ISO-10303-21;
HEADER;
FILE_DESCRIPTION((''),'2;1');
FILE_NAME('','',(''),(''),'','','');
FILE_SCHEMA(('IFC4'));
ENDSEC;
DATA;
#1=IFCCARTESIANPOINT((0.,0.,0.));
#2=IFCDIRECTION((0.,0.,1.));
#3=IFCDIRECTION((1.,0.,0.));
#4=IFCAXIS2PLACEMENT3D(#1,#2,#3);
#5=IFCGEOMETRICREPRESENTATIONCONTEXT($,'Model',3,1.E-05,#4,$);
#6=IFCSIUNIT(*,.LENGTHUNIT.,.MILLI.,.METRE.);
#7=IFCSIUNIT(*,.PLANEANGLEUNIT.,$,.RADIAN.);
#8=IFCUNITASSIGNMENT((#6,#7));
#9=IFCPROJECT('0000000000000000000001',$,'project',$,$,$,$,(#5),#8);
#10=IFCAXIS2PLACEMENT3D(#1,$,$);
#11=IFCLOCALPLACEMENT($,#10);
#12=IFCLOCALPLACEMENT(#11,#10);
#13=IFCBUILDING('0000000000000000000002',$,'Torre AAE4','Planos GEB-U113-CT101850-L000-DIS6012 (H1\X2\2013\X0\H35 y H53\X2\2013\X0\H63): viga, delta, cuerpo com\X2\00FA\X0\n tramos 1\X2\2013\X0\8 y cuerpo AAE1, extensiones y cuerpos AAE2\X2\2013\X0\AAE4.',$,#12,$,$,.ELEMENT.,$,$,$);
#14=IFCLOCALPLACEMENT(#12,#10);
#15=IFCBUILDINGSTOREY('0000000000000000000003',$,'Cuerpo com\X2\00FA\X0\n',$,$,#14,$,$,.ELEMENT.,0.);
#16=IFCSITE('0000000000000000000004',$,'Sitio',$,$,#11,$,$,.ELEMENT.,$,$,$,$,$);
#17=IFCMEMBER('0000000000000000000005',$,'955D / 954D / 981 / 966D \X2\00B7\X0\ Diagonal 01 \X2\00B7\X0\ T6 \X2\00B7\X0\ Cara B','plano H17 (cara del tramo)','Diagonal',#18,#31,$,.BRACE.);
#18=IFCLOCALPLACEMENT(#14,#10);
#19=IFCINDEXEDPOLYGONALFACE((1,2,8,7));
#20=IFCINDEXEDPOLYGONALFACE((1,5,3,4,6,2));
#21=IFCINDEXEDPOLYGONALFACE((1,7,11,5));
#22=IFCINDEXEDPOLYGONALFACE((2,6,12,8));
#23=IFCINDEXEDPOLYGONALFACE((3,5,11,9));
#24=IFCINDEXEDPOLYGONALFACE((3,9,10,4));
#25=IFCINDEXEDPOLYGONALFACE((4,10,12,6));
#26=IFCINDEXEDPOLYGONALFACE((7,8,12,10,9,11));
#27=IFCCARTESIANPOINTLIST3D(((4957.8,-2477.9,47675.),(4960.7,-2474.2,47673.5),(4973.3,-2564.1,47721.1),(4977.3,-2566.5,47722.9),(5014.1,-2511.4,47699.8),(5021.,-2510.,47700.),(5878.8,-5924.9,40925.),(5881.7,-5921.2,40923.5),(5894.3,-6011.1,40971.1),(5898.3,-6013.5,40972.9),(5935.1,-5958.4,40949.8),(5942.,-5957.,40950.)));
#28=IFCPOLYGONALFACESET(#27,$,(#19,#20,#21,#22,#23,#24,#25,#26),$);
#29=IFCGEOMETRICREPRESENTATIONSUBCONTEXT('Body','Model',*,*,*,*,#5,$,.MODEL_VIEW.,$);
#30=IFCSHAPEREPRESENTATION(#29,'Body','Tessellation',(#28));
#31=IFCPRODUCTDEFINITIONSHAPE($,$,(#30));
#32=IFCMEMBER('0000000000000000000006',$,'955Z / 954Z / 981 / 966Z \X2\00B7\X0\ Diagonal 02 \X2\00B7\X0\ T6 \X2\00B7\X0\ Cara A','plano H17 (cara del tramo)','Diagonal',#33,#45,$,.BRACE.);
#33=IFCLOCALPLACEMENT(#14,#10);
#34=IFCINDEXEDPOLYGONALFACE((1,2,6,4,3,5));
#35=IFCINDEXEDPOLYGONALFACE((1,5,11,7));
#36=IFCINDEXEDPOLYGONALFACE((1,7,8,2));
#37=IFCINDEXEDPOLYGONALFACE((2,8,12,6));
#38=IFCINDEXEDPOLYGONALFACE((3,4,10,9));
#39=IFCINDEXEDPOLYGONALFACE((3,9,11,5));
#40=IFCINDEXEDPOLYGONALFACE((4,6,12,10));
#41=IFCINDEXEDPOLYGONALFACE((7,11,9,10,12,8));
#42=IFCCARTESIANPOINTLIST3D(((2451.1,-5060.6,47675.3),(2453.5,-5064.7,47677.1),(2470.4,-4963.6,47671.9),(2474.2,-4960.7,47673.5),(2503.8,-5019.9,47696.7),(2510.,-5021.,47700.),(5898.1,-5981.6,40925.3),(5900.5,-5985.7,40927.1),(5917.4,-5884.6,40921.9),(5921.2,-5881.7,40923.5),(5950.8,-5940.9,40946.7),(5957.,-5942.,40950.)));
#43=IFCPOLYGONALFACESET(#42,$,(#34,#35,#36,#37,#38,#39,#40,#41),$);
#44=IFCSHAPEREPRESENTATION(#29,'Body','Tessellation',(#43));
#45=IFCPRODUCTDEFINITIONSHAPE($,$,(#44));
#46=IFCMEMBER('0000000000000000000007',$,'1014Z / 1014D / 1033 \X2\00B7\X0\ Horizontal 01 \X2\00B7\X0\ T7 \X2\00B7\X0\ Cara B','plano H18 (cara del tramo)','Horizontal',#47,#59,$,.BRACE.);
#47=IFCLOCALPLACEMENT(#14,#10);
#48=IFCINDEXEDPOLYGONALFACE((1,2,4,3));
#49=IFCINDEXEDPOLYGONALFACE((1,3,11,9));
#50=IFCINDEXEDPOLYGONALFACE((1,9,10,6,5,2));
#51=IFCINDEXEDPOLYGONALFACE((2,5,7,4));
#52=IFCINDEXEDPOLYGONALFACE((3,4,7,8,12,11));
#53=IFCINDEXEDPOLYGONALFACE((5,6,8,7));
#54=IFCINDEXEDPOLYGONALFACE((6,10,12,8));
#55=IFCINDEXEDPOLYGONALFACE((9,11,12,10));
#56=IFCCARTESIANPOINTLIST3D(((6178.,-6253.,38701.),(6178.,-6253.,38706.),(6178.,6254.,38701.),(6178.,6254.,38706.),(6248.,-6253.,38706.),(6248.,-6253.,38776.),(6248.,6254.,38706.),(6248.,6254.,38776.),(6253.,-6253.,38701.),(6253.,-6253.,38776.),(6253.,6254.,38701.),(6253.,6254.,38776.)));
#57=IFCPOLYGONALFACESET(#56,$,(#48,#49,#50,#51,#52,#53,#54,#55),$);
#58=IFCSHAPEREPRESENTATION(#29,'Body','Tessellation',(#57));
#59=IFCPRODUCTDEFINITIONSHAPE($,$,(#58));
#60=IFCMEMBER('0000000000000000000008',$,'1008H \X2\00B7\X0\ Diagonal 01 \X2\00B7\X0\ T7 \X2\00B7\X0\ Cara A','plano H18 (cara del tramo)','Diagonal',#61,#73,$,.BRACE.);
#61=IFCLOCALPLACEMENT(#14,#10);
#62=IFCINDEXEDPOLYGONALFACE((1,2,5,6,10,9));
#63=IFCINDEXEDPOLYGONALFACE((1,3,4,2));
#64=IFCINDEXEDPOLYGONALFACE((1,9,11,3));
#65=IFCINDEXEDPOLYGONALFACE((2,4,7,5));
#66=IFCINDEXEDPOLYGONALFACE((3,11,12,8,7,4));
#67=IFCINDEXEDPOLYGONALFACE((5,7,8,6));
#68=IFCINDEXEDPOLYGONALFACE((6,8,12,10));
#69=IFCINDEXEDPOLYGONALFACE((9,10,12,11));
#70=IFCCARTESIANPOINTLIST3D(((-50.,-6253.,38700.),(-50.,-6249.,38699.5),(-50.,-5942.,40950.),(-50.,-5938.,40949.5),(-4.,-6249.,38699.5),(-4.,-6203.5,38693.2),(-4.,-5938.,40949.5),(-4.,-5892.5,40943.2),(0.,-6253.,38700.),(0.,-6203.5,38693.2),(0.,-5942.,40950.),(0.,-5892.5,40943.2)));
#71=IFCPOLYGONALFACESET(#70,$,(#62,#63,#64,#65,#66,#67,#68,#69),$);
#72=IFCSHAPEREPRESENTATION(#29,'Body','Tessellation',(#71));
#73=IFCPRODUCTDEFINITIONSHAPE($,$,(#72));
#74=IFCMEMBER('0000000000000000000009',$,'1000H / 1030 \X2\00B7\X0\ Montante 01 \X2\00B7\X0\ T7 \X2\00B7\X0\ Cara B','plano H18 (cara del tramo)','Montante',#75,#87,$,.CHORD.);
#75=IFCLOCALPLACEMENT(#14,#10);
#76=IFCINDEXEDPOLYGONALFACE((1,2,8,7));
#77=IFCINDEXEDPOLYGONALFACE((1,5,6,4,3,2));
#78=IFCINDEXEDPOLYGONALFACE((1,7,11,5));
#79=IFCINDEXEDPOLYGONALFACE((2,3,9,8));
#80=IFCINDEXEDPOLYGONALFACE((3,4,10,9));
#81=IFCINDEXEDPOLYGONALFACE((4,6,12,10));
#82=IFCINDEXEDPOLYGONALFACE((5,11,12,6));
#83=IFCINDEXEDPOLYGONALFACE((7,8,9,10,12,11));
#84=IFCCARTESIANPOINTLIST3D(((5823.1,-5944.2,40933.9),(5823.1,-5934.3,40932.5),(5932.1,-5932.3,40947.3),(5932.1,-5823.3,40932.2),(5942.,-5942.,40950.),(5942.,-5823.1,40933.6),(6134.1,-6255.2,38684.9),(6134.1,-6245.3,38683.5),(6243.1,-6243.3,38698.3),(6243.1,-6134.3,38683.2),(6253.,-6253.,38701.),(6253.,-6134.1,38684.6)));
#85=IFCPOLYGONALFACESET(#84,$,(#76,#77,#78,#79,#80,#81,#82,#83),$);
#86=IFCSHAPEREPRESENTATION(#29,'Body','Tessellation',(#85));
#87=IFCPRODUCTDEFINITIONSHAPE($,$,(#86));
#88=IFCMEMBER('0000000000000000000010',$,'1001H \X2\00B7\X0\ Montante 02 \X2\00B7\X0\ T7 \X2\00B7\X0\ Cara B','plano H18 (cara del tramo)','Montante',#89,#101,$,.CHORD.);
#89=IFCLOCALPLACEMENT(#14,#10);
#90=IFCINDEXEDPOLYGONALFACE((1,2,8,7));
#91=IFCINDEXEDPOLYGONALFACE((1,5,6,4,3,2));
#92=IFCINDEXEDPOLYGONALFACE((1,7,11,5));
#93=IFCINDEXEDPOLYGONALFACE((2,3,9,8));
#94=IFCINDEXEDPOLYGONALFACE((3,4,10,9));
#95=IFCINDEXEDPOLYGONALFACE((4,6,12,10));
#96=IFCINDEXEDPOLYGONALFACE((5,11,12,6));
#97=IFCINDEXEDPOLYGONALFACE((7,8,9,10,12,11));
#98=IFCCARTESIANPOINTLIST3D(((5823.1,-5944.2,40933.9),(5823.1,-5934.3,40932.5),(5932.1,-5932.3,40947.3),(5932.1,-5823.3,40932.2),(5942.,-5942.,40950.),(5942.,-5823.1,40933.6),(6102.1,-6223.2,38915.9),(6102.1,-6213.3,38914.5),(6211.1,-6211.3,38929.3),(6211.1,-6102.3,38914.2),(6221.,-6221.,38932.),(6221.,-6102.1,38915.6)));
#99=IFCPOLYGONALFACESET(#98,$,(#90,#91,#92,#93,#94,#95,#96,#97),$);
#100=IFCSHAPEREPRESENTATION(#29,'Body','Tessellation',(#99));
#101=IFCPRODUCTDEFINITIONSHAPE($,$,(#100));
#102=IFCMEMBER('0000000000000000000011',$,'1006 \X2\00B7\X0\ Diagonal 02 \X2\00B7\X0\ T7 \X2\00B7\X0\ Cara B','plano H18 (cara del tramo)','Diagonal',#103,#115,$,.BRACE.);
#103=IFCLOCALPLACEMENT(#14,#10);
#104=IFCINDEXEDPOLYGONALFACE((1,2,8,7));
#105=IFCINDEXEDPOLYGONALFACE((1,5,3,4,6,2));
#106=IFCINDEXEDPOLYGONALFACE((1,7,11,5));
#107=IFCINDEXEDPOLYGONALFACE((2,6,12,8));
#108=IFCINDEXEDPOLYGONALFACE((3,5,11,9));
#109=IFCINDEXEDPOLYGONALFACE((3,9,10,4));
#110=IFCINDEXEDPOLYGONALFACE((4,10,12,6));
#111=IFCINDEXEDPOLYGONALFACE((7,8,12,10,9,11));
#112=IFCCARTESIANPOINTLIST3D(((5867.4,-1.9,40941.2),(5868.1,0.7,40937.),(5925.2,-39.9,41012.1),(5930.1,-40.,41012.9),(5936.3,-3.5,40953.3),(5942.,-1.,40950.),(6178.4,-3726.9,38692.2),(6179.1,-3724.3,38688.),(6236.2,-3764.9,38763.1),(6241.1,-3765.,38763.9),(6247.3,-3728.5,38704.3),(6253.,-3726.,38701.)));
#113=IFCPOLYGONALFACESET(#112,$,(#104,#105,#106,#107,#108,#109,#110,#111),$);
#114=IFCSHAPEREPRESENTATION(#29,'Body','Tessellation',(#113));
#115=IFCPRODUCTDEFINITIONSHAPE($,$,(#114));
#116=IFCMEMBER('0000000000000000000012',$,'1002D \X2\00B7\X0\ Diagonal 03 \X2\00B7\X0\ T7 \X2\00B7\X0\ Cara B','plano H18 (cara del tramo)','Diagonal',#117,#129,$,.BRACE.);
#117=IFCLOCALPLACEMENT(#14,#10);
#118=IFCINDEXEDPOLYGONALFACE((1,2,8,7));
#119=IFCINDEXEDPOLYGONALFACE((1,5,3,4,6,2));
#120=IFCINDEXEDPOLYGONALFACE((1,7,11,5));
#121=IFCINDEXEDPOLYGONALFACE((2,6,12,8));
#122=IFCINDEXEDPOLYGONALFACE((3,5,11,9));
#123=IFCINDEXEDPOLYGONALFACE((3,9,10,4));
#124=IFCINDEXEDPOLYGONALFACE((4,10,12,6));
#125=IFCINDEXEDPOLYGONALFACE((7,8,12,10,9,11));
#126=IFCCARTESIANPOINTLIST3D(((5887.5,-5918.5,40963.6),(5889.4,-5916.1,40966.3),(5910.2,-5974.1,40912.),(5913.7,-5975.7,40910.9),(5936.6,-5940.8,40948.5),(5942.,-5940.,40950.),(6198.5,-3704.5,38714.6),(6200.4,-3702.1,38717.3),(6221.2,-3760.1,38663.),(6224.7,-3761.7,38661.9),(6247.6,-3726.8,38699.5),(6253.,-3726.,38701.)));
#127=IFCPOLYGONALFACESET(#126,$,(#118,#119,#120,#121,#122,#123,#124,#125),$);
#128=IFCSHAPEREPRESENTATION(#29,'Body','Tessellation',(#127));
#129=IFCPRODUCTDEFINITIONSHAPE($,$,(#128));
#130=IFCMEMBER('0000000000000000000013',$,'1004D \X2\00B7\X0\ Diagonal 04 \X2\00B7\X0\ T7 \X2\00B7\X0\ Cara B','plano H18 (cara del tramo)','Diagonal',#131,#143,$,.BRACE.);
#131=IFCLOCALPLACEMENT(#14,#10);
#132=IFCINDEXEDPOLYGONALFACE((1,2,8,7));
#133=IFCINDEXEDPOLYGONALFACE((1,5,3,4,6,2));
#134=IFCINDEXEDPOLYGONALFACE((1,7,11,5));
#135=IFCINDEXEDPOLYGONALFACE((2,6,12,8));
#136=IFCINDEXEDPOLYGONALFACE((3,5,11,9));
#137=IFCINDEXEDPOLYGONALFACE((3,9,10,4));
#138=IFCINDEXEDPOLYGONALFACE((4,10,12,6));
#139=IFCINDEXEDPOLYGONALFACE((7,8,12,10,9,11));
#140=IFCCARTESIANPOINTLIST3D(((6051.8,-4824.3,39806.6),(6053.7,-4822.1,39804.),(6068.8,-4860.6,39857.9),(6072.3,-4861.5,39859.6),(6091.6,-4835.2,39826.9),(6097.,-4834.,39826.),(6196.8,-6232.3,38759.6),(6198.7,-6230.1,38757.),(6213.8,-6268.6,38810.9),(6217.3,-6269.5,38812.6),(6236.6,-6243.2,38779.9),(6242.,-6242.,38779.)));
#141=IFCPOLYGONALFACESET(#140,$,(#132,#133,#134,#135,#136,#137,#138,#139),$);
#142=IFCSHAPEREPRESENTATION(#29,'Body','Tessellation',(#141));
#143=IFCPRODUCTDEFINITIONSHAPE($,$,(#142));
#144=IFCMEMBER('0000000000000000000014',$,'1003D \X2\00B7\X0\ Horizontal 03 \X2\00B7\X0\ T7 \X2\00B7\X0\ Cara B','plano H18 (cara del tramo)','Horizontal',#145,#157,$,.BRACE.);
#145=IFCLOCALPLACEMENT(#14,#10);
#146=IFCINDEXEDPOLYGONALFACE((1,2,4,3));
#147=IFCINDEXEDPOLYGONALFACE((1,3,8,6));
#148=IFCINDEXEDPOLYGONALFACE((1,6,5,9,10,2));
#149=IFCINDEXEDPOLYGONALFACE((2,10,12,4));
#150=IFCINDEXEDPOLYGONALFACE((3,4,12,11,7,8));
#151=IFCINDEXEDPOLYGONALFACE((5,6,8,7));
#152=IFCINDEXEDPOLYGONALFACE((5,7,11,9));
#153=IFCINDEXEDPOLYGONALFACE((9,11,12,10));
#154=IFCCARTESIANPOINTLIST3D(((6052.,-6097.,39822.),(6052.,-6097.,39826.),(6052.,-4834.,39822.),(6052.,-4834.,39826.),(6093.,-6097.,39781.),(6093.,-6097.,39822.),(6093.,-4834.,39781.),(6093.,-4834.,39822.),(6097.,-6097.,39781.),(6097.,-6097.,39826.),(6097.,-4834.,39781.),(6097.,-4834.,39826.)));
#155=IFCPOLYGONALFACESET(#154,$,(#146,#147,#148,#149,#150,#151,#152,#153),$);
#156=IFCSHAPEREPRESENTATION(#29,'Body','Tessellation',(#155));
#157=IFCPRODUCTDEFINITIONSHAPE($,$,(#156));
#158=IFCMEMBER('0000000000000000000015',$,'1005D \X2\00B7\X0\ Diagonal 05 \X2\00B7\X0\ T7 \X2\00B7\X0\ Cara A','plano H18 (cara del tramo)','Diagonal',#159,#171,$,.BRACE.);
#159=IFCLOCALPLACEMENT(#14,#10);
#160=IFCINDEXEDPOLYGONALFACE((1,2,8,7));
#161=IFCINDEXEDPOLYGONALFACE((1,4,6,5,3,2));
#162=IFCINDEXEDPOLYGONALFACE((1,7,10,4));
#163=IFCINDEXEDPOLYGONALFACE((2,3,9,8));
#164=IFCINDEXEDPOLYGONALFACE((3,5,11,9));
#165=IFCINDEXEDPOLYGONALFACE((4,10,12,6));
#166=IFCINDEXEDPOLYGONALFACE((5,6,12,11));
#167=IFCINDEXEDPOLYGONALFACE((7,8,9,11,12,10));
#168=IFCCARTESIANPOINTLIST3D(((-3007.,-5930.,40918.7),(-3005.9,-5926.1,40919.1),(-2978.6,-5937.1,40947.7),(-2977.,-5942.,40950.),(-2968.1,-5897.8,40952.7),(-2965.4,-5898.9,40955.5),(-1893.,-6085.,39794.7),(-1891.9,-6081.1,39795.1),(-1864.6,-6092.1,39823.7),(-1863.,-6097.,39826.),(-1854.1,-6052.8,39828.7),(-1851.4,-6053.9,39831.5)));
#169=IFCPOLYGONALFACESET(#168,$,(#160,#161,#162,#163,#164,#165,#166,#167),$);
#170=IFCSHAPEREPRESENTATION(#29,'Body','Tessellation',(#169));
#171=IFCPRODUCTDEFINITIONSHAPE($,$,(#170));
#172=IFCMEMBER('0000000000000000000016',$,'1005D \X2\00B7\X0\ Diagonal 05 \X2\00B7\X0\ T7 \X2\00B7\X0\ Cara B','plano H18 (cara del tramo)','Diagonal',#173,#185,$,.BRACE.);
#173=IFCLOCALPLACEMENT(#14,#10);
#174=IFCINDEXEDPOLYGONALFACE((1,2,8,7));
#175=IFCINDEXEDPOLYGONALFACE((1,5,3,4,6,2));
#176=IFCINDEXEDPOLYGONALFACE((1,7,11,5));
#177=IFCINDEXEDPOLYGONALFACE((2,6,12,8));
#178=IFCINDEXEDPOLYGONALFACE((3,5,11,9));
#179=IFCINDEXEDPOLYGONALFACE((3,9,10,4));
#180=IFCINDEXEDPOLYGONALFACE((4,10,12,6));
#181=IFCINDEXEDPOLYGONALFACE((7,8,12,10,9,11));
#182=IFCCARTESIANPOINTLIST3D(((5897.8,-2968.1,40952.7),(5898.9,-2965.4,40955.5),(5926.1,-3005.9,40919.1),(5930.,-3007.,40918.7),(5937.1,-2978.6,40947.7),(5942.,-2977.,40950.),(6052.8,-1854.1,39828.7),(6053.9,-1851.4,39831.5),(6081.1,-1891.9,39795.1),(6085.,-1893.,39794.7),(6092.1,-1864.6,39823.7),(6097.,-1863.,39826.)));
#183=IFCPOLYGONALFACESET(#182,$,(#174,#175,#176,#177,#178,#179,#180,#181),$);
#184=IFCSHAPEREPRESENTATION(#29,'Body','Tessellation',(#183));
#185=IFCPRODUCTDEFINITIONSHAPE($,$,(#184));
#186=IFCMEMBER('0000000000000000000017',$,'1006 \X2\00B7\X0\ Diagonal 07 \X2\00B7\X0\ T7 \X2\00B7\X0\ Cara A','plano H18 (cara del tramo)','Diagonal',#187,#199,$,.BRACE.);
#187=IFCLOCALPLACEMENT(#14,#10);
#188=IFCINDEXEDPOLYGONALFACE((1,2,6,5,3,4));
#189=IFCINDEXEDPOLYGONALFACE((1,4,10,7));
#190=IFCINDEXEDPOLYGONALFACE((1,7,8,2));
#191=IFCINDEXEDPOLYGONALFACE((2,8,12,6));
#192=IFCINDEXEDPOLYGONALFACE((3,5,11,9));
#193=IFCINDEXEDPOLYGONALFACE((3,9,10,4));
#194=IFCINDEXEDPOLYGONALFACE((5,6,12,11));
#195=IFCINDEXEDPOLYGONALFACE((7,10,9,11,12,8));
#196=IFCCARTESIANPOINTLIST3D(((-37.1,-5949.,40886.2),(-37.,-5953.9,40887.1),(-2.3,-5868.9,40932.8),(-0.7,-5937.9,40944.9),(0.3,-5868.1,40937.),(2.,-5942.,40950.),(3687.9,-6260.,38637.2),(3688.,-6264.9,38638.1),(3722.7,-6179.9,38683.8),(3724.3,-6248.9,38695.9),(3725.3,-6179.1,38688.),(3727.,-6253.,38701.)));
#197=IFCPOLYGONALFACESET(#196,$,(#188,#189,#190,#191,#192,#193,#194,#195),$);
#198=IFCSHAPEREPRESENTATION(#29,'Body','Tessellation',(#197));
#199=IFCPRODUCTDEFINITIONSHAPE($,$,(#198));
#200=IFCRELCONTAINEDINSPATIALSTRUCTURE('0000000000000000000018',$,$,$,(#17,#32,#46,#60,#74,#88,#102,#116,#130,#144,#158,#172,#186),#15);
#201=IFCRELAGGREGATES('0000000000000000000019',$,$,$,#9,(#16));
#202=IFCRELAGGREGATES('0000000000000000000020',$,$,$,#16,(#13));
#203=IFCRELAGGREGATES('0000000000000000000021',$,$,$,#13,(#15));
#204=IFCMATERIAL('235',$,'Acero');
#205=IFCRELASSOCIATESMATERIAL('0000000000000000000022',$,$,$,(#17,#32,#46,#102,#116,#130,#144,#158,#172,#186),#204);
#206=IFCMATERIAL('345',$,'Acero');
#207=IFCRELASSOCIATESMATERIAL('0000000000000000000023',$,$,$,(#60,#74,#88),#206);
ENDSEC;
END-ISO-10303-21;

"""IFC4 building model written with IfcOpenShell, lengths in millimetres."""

from ifc_helpers import new_model, si_unit, frame, frame_2d, origin, origin_with_axes, place, context, subcontext, project, spatial, l_section, extrude, material, element, save


model = new_model("IFC4")

# Units and contexts
model_context = context("Model", 3, precision=1e-05, world=origin_with_axes())
body_context = subcontext(model_context, "Body", "Model", "MODEL_VIEW")
ifc_project = project(units=[si_unit("LENGTHUNIT", "METRE", prefix="MILLI"), si_unit("PLANEANGLEUNIT", "RADIAN")], contexts=[model_context])

# Site, building, storey
site_placement = place(None, origin())
site = spatial("IfcSite", under=ifc_project, at=site_placement, Name="Sitio", CompositionType="ELEMENT")
building_placement = place(site_placement, origin())
building = spatial("IfcBuilding", under=site, at=building_placement, Name="Torre AAE4", Description="Planos GEB-U113-CT101850-L000-DIS6012 (H1–H35 y H53–H63): viga, delta, cuerpo común tramos 1–8 y cuerpo AAE1, extensiones y cuerpos AAE2–AAE4.", CompositionType="ELEMENT")
storey_placement = place(building_placement, origin())
storey = spatial("IfcBuildingStorey", under=building, at=storey_placement, Name="Cuerpo común", CompositionType="ELEMENT", Elevation=0.0)

# Members
ifc_material_1 = material(Name="235", Category="Acero")
for number, where, z_axis, x_axis, name in (
    (1, (5942.0, -5957.0, 40950.0), (-0.120629, 0.451476, 0.884092), (-0.804164, 0.477732, -0.353685), "955D / 954D / 981 / 966D · Diagonal 01 · T6 · Cara B"),
    (2, (5957.0, -5942.0, 40950.0), (-0.451476, 0.120629, 0.884092), (-0.477732, 0.804164, -0.353685), "955Z / 954Z / 981 / 966Z · Diagonal 02 · T6 · Cara A"),
):
    element("IfcMember", number, at=place(storey_placement, frame(where, z_axis=z_axis, x_axis=x_axis)), inside=storey, material=ifc_material_1, Name=name, Description="plano H17 (cara del tramo)", ObjectType="Diagonal", PredefinedType="BRACE", context=body_context, shape_type="SweptSolid", body=[
        extrude(l_section(Depth=75.0, Width=75.0, Thickness=5.0, at=frame_2d((37.5, 37.5))), None, (0.0, 0.0, 1.0), 7635.0),
    ])
member_1_placement = place(storey_placement, frame((6253.0, -6253.0, 38701.0), z_axis=(0.0, 1.0, 0.0), x_axis=(-1.0, 0.0, 0.0)))
element("IfcMember", 3, at=member_1_placement, inside=storey, material=ifc_material_1, Name="1014Z / 1014D / 1033 · Horizontal 01 · T7 · Cara B", Description="plano H18 (cara del tramo)", ObjectType="Horizontal", PredefinedType="BRACE", context=body_context, shape_type="SweptSolid", body=[
    extrude(l_section(Depth=75.0, Width=75.0, Thickness=5.0, at=frame_2d((37.5, 37.5))), None, (0.0, 0.0, 1.0), 12507.0),
])
ifc_material_2 = material(Name="345", Category="Acero")
member_2_placement = place(storey_placement, frame((0.0, -6253.0, 38700.0), z_axis=(0.0, 0.13692, 0.990582), x_axis=(0.0, 0.990582, -0.13692)))
element("IfcMember", 4, at=member_2_placement, inside=storey, material=ifc_material_2, Name="1008H · Diagonal 01 · T7 · Cara A", Description="plano H18 (cara del tramo)", ObjectType="Diagonal", PredefinedType="BRACE", context=body_context, shape_type="SweptSolid", body=[
    extrude(l_section(Depth=50.0, Width=50.0, Thickness=4.0, at=frame_2d((25.0, 25.0))), None, (0.0, 0.0, 1.0), 2271.4),
])
member_3_placement = place(storey_placement, frame((5942.0, -5942.0, 40950.0), z_axis=(0.135713, -0.135713, -0.981409), x_axis=(-0.990748, -0.01859, -0.134434)))
element("IfcMember", 5, at=member_3_placement, inside=storey, material=ifc_material_2, Name="1000H / 1030 · Montante 01 · T7 · Cara B", Description="plano H18 (cara del tramo)", ObjectType="Montante", PredefinedType="CHORD", context=body_context, shape_type="SweptSolid", body=[
    extrude(l_section(Depth=120.0, Width=120.0, Thickness=10.0, at=frame_2d((60.0, 60.0))), None, (0.0, 0.0, 1.0), 2291.6),
])
member_4_placement = place(storey_placement, frame((5942.0, -5942.0, 40950.0), z_axis=(0.135686, -0.135686, -0.981417), x_axis=(-0.990752, -0.018583, -0.134408)))
element("IfcMember", 6, at=member_4_placement, inside=storey, material=ifc_material_2, Name="1001H · Montante 02 · T7 · Cara B", Description="plano H18 (cara del tramo)", ObjectType="Montante", PredefinedType="CHORD", context=body_context, shape_type="SweptSolid", body=[
    extrude(l_section(Depth=120.0, Width=120.0, Thickness=10.0, at=frame_2d((60.0, 60.0))), None, (0.0, 0.0, 1.0), 2056.2),
])
member_5_placement = place(storey_placement, frame((6253.0, -3726.0, 38701.0), z_axis=(-0.071291, 0.853892, 0.515544), x_axis=(-0.984715, 0.022095, -0.172766)))
element("IfcMember", 7, at=member_5_placement, inside=storey, material=ifc_material_1, Name="1006 · Diagonal 02 · T7 · Cara B", Description="plano H18 (cara del tramo)", ObjectType="Diagonal", PredefinedType="BRACE", context=body_context, shape_type="SweptSolid", body=[
    extrude(l_section(Depth=75.0, Width=75.0, Thickness=5.0, at=frame_2d((37.5, 37.5))), None, (0.0, 0.0, 1.0), 4362.4),
])
member_6_placement = place(storey_placement, frame((6253.0, -3726.0, 38701.0), z_axis=(-0.09807, -0.698158, 0.709195), x_axis=(-0.876361, 0.398265, 0.270881)))
element("IfcMember", 8, at=member_6_placement, inside=storey, material=ifc_material_1, Name="1002D · Diagonal 03 · T7 · Cara B", Description="plano H18 (cara del tramo)", ObjectType="Diagonal", PredefinedType="BRACE", context=body_context, shape_type="SweptSolid", body=[
    extrude(l_section(Depth=60.0, Width=60.0, Thickness=4.0, at=frame_2d((30.0, 30.0))), None, (0.0, 0.0, 1.0), 3171.2),
])
member_7_placement = place(storey_placement, frame((6242.0, -6242.0, 38779.0), z_axis=(-0.082358, 0.799729, 0.594685), x_axis=(-0.865275, 0.238691, -0.440823)))
element("IfcMember", 9, at=member_7_placement, inside=storey, material=ifc_material_1, Name="1004D · Diagonal 04 · T7 · Cara B", Description="plano H18 (cara del tramo)", ObjectType="Diagonal", PredefinedType="BRACE", context=body_context, shape_type="SweptSolid", body=[
    extrude(l_section(Depth=50.0, Width=50.0, Thickness=4.0, at=frame_2d((25.0, 25.0))), None, (0.0, 0.0, 1.0), 1760.6),
])
member_8_placement = place(storey_placement, frame((6097.0, -4834.0, 39826.0), z_axis=(0.0, -1.0, 0.0), x_axis=(-1.0, 0.0, 0.0)))
element("IfcMember", 10, at=member_8_placement, inside=storey, material=ifc_material_1, Name="1003D · Horizontal 03 · T7 · Cara B", Description="plano H18 (cara del tramo)", ObjectType="Horizontal", PredefinedType="BRACE", context=body_context, shape_type="SweptSolid", body=[
    extrude(l_section(Depth=45.0, Width=45.0, Thickness=4.0, at=frame_2d((22.5, 22.5))), None, (0.0, 0.0, 1.0), 1263.0),
])
for number, where, z_axis, x_axis, name in (
    (11, (-1863.0, -6097.0, 39826.0), (-0.700588, 0.097479, 0.706877), (0.257073, 0.958584, 0.122597), "1005D · Diagonal 05 · T7 · Cara A"),
    (12, (6097.0, -1863.0, 39826.0), (-0.097479, -0.700588, 0.706877), (-0.958584, 0.257073, 0.122597), "1005D · Diagonal 05 · T7 · Cara B"),
):
    element("IfcMember", number, at=place(storey_placement, frame(where, z_axis=z_axis, x_axis=x_axis)), inside=storey, material=ifc_material_1, Name=name, Description="plano H18 (cara del tramo)", ObjectType="Diagonal", PredefinedType="BRACE", context=body_context, shape_type="SweptSolid", body=[
        extrude(l_section(Depth=45.0, Width=45.0, Thickness=4.0, at=frame_2d((22.5, 22.5))), None, (0.0, 0.0, 1.0), 1590.1),
    ])
member_9_placement = place(storey_placement, frame((3727.0, -6253.0, 38701.0), z_axis=(-0.853892, 0.071291, 0.515544), x_axis=(-0.02214, 0.984701, -0.172839)))
element("IfcMember", 13, at=member_9_placement, inside=storey, material=ifc_material_1, Name="1006 · Diagonal 07 · T7 · Cara A", Description="plano H18 (cara del tramo)", ObjectType="Diagonal", PredefinedType="BRACE", context=body_context, shape_type="SweptSolid", body=[
    extrude(l_section(Depth=75.0, Width=75.0, Thickness=5.0, at=frame_2d((37.5, 37.5))), None, (0.0, 0.0, 1.0), 4362.4),
])

save(model, "model.ifc")
